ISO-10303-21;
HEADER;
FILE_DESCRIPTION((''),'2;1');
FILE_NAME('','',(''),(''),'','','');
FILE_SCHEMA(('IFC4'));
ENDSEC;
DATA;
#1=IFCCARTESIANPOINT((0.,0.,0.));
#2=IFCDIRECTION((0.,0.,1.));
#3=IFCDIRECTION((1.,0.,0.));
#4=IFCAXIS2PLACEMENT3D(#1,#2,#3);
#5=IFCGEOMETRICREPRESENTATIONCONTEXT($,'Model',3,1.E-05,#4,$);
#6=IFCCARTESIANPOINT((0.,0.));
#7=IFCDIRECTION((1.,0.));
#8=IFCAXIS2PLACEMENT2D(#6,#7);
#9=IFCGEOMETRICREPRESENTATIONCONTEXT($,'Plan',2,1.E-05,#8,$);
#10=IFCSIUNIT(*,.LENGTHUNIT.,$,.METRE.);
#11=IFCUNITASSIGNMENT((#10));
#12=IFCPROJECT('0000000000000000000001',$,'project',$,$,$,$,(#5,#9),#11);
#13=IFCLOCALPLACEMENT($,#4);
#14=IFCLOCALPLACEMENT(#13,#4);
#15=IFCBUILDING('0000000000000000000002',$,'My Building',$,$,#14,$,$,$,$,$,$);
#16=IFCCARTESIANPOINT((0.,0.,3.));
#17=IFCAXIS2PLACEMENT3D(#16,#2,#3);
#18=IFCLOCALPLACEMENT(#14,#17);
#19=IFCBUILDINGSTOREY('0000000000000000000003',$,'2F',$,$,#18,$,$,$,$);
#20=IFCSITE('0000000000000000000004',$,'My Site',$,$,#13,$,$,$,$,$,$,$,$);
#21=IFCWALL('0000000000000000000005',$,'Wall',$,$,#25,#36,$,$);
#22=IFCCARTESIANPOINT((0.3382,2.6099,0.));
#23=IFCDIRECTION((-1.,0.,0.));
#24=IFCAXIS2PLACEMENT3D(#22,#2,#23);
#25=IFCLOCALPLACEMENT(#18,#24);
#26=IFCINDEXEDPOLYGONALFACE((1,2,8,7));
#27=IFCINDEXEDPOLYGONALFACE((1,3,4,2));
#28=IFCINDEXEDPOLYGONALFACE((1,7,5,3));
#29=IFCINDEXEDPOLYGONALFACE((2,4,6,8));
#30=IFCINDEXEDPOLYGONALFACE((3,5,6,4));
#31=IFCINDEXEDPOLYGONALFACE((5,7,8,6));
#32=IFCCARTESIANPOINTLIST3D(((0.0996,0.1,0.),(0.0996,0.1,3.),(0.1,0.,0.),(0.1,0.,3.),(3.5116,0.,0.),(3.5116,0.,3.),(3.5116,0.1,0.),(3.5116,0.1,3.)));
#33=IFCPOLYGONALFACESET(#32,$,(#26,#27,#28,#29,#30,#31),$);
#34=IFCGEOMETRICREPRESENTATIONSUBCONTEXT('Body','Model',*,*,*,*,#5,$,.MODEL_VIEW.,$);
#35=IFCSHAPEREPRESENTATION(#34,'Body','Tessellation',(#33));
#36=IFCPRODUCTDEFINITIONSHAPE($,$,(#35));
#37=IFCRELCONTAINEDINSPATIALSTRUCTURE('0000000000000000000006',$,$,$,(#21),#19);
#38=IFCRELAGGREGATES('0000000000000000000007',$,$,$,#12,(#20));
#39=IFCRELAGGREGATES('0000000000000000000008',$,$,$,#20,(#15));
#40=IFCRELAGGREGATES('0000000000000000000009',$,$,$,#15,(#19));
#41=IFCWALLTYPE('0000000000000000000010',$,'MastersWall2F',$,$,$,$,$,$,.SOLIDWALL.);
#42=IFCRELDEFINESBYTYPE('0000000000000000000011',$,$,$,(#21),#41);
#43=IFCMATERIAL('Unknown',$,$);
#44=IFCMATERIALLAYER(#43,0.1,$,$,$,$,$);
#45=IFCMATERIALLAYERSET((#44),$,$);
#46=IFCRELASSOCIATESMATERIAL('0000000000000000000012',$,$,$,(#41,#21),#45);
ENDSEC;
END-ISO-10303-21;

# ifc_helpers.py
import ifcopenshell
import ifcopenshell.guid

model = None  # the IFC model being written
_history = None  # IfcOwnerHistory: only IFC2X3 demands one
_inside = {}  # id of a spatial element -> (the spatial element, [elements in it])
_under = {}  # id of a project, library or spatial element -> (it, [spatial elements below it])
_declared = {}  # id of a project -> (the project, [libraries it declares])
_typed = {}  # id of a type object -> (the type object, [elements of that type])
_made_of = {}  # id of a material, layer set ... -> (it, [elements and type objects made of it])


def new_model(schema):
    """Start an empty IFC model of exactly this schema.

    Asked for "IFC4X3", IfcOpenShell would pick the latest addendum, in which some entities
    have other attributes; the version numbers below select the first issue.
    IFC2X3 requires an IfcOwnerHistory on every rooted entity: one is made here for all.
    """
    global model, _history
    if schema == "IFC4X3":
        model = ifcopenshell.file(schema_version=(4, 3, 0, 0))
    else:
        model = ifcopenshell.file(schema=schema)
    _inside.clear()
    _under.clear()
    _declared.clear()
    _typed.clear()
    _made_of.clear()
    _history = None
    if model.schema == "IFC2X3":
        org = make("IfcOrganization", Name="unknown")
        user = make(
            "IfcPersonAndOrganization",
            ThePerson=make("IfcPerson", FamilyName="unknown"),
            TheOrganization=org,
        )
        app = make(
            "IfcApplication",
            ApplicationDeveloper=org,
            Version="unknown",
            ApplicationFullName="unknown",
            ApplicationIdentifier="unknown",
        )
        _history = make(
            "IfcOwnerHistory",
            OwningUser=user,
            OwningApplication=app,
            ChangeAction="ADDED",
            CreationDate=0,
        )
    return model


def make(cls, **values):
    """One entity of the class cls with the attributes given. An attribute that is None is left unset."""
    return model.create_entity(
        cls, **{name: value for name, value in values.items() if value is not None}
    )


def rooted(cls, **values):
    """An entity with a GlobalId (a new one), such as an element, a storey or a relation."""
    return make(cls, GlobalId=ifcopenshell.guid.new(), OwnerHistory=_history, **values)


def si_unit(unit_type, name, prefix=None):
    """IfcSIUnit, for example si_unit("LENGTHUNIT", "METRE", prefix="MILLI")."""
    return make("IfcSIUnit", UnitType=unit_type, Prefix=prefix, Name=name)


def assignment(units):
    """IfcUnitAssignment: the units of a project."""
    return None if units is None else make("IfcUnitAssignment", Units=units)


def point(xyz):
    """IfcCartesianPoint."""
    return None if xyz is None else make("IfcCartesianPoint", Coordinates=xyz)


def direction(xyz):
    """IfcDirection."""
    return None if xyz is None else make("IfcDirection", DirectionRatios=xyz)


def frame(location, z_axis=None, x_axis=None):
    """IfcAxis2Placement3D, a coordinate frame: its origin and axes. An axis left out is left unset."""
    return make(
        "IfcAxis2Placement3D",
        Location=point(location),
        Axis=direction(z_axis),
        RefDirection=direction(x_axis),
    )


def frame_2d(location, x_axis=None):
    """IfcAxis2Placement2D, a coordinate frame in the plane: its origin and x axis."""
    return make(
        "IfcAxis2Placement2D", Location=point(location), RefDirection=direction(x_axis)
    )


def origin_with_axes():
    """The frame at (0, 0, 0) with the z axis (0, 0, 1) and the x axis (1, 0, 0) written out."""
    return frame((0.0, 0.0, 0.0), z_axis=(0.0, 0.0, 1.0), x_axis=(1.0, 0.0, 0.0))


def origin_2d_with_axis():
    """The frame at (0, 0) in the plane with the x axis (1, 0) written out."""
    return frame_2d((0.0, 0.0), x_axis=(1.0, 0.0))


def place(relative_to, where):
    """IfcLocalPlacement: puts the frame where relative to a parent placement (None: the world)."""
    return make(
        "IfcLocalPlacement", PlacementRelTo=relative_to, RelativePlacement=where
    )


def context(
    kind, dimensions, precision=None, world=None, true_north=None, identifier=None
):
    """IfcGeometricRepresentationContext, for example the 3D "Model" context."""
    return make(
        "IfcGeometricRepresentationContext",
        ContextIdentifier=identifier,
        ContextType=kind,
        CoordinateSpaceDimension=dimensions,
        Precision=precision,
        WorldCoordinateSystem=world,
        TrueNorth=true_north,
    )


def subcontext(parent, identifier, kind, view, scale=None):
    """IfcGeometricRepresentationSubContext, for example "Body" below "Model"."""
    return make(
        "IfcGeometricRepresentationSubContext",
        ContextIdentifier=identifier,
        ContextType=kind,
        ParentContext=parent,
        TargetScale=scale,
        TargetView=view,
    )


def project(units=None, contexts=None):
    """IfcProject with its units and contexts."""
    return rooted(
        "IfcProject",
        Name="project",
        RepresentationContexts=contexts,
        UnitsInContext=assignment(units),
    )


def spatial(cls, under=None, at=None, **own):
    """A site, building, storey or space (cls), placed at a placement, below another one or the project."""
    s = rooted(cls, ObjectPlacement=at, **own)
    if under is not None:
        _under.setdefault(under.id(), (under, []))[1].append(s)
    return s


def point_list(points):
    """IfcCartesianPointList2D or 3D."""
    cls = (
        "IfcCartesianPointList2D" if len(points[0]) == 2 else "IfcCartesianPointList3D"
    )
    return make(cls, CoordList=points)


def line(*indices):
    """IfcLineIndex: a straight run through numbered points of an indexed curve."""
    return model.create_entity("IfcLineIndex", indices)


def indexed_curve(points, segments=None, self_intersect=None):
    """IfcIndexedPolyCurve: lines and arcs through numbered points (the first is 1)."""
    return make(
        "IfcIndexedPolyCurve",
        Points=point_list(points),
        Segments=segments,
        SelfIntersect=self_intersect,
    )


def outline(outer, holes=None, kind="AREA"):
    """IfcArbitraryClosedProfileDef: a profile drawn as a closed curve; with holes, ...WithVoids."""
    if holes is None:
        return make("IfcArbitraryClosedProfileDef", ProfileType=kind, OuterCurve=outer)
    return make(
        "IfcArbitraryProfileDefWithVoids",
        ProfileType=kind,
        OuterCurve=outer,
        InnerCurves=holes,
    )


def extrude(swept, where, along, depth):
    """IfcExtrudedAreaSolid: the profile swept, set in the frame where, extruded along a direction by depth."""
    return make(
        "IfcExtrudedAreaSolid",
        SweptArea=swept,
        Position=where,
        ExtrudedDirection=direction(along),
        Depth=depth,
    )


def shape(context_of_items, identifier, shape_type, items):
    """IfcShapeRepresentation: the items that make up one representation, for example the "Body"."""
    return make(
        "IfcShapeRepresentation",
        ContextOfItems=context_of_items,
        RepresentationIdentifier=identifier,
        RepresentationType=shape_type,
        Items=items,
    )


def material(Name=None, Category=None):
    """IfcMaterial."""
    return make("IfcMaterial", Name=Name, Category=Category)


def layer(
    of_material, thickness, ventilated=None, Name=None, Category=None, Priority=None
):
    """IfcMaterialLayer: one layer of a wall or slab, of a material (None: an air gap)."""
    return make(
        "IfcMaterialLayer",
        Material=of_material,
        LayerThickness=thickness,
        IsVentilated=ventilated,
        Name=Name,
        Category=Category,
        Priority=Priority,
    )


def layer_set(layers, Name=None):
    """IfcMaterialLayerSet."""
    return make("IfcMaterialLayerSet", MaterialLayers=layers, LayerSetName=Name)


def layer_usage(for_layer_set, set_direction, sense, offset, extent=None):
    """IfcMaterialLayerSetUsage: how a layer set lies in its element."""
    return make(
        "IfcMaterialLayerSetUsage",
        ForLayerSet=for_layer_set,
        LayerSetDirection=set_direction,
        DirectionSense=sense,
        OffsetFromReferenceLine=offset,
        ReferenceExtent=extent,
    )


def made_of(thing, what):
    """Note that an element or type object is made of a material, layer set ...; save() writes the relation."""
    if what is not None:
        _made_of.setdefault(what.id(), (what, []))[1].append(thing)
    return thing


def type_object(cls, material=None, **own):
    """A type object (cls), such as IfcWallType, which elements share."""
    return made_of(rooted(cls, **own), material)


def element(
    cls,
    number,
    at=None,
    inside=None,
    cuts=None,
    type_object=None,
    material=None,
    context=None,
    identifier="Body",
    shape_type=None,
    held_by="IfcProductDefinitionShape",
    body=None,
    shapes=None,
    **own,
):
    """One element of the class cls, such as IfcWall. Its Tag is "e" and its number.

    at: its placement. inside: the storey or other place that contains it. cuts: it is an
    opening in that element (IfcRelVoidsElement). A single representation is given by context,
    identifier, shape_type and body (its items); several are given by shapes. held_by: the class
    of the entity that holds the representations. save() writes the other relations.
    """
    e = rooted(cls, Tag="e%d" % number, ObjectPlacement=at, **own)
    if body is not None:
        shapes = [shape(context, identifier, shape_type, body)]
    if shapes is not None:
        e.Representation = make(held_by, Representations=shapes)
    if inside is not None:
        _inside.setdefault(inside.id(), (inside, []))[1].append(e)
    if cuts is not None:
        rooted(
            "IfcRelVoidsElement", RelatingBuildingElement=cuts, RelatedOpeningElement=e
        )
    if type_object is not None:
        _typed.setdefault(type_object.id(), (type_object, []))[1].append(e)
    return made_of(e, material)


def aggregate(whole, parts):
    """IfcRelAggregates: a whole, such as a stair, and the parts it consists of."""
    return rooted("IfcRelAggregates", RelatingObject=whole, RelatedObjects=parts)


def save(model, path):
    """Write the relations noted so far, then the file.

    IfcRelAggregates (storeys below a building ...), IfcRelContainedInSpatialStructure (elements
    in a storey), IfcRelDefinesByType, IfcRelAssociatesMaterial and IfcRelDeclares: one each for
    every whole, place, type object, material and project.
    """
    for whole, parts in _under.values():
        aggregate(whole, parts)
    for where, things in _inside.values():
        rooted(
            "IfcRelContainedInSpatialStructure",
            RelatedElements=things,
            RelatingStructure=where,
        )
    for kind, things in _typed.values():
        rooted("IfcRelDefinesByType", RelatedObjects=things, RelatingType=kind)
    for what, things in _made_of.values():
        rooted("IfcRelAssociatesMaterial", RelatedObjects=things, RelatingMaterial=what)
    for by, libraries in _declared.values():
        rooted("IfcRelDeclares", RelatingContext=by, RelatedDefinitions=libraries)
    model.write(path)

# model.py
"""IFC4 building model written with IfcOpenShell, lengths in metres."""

from ifc_helpers import new_model, si_unit, frame, origin_with_axes, origin_2d_with_axis, place, context, subcontext, project, spatial, line, indexed_curve, outline, extrude, material, layer, layer_set, layer_usage, type_object, element, save


model = new_model("IFC4")

# Units and contexts
model_context = context("Model", 3, precision=1e-05, world=origin_with_axes())
plan_context = context("Plan", 2, precision=1e-05, world=origin_2d_with_axis())
body_context_1 = subcontext(model_context, "Body", "Model", "MODEL_VIEW")
ifc_project = project(units=[si_unit("LENGTHUNIT", "METRE")], contexts=[model_context, plan_context])

# Site, building, storey
site_placement = place(None, origin_with_axes())
site = spatial("IfcSite", under=ifc_project, at=site_placement, Name="My Site")
building_placement = place(site_placement, origin_with_axes())
building = spatial("IfcBuilding", under=site, at=building_placement, Name="My Building")
storey_placement = place(building_placement, frame((0.0, 0.0, 3.0), z_axis=(0.0, 0.0, 1.0), x_axis=(1.0, 0.0, 0.0)))
storey = spatial("IfcBuildingStorey", under=building, at=storey_placement, Name="2F")

# Shared definitions
ifc_material = material(Name="Unknown")

# Wall
ifc_layer_1 = layer(ifc_material, 0.1)
ifc_layer_set_1 = layer_set([ifc_layer_1])
ifc_layer_usage_1 = layer_usage(ifc_layer_set_1, "AXIS2", "POSITIVE", 0.0)
wall_type_1 = type_object("IfcWallType", Name="MastersWall2F", PredefinedType="SOLIDWALL", material=ifc_layer_set_1)
wall_1_placement = place(storey_placement, frame((0.3382, 2.6099, 0.0), z_axis=(0.0, 0.0, 1.0), x_axis=(-1.0, 0.0, 0.0)))
element("IfcWall", 1, at=wall_1_placement, inside=storey, type_object=wall_type_1, material=ifc_layer_usage_1, Name="Wall", context=body_context_1, shape_type="SweptSolid", body=[
    extrude(outline(indexed_curve([(0.1, 0.0), (0.0996, 0.1), (3.5116, 0.1), (3.5116, 0.0)], segments=[line(1, 2, 3, 4, 1)])), origin_with_axes(), (0.0, 0.0, 1.0), 3.0),
])

save(model, "model.ifc")
